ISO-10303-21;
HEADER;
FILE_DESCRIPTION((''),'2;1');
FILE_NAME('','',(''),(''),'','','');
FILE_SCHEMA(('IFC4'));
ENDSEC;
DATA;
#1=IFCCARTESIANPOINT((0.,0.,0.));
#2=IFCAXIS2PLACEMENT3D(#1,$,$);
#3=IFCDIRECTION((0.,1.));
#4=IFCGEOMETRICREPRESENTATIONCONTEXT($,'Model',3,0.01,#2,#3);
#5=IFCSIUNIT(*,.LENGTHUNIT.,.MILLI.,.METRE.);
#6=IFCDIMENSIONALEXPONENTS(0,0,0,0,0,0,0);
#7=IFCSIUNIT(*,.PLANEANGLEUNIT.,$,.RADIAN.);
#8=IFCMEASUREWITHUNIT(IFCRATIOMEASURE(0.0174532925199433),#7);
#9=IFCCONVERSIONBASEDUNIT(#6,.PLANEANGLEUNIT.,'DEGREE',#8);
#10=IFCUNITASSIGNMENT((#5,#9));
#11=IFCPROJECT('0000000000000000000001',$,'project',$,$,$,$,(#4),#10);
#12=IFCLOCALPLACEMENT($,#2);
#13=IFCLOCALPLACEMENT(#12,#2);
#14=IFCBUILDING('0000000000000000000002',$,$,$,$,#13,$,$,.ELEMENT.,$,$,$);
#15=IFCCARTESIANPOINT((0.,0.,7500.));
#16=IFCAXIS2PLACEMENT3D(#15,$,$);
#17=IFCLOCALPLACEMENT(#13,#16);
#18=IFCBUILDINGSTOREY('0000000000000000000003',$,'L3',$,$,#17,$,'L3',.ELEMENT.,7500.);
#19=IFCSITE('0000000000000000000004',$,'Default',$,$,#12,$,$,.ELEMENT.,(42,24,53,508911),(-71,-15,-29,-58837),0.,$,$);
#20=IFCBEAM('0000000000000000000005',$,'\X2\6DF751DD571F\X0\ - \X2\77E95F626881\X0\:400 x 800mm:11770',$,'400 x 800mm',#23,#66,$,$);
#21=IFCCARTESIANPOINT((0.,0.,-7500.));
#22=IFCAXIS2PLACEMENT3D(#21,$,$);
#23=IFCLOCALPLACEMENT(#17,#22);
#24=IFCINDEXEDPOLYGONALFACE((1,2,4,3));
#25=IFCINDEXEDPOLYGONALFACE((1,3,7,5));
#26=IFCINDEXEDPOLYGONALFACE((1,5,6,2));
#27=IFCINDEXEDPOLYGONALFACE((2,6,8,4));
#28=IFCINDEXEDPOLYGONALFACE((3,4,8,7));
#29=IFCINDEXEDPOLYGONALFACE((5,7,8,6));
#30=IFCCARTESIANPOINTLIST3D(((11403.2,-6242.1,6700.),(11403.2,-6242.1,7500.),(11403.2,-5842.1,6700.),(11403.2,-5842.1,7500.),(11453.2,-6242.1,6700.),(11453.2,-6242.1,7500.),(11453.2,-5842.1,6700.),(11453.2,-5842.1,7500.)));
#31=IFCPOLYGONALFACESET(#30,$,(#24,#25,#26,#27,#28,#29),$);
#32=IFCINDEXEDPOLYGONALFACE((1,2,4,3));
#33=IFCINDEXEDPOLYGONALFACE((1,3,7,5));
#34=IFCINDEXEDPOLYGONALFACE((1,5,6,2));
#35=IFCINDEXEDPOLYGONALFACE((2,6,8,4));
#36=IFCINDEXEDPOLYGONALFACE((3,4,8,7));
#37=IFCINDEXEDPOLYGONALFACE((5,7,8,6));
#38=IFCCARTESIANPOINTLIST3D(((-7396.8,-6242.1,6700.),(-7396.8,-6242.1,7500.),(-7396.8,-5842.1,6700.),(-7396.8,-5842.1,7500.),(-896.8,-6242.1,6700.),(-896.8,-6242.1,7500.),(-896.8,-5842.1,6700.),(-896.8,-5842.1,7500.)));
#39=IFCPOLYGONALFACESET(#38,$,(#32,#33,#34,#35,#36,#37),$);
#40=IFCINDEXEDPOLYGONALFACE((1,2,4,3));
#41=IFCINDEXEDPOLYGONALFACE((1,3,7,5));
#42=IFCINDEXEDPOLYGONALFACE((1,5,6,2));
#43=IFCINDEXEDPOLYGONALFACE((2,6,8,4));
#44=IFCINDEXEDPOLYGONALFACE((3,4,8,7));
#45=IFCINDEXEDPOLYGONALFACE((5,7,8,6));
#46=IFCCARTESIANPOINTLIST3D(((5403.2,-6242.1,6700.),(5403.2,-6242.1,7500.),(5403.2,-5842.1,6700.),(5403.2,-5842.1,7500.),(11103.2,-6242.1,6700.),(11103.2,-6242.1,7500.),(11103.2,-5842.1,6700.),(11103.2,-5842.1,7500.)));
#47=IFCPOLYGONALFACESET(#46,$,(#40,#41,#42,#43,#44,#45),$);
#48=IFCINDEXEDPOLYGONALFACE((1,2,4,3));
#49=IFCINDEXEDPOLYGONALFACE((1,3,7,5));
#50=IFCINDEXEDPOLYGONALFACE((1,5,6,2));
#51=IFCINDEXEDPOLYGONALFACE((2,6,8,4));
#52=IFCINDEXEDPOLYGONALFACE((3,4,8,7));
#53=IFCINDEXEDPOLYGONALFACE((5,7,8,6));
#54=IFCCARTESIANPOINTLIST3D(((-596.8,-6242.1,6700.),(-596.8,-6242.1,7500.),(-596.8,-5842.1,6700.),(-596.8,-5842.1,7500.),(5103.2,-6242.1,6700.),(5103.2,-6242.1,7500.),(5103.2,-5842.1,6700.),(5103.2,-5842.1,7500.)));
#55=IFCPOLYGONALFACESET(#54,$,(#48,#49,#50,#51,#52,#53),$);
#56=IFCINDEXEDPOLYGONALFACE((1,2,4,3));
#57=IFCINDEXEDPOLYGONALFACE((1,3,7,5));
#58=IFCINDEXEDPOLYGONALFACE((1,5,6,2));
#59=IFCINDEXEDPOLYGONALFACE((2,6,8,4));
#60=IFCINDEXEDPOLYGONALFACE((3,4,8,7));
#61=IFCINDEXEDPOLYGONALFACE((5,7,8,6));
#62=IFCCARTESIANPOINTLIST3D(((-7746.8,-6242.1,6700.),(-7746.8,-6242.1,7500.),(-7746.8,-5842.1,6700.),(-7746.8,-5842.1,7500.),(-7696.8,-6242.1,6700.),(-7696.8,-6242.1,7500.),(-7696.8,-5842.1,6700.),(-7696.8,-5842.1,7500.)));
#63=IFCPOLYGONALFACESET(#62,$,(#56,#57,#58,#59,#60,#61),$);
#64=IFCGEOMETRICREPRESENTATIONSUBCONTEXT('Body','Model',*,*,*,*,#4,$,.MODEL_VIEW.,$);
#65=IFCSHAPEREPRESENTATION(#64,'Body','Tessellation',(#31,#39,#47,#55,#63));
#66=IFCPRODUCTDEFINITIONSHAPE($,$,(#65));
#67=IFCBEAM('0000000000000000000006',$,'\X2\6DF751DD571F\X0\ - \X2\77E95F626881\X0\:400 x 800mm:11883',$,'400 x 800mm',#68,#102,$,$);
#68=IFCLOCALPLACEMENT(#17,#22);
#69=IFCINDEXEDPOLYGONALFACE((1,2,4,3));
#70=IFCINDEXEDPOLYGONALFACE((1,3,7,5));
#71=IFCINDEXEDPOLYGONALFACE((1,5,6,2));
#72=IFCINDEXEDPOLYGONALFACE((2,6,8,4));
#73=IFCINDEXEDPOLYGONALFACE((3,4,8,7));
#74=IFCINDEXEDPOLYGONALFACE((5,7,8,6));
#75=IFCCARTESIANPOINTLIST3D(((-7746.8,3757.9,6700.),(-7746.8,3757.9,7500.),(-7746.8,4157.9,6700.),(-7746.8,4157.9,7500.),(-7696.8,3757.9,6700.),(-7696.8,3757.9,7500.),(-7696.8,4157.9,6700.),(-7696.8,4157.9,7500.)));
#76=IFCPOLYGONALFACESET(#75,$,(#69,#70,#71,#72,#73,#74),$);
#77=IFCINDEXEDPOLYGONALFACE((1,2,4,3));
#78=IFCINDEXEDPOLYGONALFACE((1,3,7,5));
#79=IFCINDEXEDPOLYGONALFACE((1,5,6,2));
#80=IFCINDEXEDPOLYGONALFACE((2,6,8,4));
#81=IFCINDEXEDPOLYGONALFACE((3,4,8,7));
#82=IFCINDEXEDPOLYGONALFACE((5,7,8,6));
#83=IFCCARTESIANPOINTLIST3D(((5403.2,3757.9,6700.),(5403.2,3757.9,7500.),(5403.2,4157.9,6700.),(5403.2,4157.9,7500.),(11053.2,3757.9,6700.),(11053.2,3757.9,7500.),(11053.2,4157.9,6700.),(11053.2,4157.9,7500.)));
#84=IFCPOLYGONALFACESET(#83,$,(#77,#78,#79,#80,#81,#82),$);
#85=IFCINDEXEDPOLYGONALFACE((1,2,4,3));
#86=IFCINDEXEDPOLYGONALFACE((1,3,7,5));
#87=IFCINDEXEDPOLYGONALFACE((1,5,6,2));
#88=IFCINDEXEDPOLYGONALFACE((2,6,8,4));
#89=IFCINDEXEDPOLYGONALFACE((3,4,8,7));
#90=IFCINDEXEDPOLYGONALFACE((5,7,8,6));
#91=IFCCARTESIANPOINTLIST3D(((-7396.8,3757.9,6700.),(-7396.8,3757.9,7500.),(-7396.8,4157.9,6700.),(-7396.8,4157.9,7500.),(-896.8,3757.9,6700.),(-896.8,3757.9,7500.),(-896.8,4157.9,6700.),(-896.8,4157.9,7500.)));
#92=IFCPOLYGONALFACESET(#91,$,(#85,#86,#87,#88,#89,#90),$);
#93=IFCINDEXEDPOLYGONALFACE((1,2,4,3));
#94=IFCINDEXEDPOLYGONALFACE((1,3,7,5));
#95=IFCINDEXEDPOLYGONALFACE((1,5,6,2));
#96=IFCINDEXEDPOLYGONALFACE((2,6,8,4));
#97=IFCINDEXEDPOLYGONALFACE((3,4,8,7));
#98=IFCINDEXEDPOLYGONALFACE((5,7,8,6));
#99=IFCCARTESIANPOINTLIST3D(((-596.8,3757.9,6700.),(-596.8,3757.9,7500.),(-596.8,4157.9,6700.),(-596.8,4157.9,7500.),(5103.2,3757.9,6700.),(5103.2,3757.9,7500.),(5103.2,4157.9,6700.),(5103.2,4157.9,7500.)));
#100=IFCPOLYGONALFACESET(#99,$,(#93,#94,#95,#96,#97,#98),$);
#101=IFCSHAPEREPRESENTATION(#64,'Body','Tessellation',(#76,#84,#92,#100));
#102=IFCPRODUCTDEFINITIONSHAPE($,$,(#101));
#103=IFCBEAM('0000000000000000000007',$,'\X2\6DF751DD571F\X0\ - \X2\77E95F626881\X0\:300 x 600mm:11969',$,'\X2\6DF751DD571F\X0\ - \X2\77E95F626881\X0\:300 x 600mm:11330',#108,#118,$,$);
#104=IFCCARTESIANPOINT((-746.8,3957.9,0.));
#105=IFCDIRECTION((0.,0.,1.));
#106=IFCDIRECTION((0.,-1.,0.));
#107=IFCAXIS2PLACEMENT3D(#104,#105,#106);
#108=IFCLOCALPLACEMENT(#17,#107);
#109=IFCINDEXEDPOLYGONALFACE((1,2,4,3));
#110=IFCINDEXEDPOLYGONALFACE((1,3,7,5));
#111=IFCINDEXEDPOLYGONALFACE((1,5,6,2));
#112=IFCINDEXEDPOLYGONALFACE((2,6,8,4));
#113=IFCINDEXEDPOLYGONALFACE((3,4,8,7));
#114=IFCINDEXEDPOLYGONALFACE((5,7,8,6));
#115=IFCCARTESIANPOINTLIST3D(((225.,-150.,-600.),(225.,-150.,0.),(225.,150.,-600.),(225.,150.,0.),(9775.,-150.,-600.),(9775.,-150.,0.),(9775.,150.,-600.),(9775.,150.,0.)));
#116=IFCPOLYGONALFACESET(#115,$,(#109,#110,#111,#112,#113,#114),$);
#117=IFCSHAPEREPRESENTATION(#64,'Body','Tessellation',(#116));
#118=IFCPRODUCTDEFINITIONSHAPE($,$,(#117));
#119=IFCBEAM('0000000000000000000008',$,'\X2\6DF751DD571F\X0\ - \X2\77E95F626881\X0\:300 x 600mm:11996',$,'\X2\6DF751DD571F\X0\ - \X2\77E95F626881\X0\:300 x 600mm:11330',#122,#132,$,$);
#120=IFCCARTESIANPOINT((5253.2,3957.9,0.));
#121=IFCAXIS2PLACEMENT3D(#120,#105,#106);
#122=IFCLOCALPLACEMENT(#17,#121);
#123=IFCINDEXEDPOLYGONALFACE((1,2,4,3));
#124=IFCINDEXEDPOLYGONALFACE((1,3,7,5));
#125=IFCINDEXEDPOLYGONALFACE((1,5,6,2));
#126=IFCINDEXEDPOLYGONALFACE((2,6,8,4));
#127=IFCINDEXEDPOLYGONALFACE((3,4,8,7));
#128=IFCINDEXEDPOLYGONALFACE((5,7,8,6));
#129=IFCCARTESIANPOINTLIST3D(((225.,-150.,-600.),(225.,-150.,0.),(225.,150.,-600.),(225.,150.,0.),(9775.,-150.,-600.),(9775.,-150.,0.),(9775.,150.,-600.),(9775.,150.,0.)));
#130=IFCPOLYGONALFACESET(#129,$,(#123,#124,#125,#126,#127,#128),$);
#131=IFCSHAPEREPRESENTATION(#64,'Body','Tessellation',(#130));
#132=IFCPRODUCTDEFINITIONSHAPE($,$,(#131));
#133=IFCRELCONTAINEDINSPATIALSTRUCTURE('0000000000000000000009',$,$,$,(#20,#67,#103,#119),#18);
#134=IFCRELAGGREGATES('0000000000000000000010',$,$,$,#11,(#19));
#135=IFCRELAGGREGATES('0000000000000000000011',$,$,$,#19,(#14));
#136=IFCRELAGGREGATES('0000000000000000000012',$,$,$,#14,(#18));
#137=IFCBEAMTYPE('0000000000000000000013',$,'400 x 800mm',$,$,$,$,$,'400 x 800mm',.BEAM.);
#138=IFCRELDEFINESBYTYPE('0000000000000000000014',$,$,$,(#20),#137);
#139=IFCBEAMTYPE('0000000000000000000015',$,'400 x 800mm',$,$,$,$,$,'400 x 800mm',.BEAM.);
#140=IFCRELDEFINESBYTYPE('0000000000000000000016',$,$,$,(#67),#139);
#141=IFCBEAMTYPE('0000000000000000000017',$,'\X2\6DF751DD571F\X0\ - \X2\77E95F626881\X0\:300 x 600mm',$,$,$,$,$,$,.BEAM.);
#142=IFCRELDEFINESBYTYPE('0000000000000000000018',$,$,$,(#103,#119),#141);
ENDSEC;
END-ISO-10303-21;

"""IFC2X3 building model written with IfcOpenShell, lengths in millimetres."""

from ifc_helpers import new_model, entity, si_unit, converted_unit, direction, frame, frame_2d, origin, origin_2d_with_axis, place, context, subcontext, project, spatial, rectangle, extrude, source, transform, mapped, type_object, type_shapes, element, save


model = new_model("IFC2X3")

# Units and contexts
model_context = context("Model", 3, precision=0.01, world=origin(), true_north=direction((0.0, 1.0)))
body_context = subcontext(model_context, "Body", "Model", "MODEL_VIEW")
ifc_project = project(units=[si_unit("LENGTHUNIT", "METRE", prefix="MILLI"), converted_unit("PLANEANGLEUNIT", "DEGREE", entity("IfcRatioMeasure", 0.0174532925199433), si_unit("PLANEANGLEUNIT", "RADIAN"), dimensions=[0, 0, 0, 0, 0, 0, 0])], contexts=[model_context])

# Site, building, storey
site_placement = place(None, origin())
site = spatial("IfcSite", under=ifc_project, at=site_placement, Name="Default", CompositionType="ELEMENT", RefLatitude=(42, 24, 53, 508911), RefLongitude=(-71, -15, -29, -58837), RefElevation=0.0)
building_placement = place(site_placement, origin())
building = spatial("IfcBuilding", under=site, at=building_placement, CompositionType="ELEMENT")
storey_placement = place(building_placement, frame((0.0, 0.0, 7500.0)))
storey = spatial("IfcBuildingStorey", under=building, at=storey_placement, Name="L3", LongName="L3", CompositionType="ELEMENT", Elevation=7500.0)

# Beams
beam_type_1 = type_object("IfcBeamType", Name="400 x 800mm", ElementType="400 x 800mm", PredefinedType="BEAM")
shared_shape_1 = source(origin(), body_context, "Body", "SweptSolid", [
    extrude(rectangle(XDim=50.0, YDim=400.0, at=frame_2d((0.0, 0.0), x_axis=(1.0, 0.0))), frame((11428.2, -6042.1, 6700.0), z_axis=(0.0, 0.0, 1.0), x_axis=(-1.0, 0.0, 0.0)), (0.0, 0.0, 1.0), 800.0),
    extrude(rectangle(XDim=6500.0, YDim=400.0, at=frame_2d((640.0, -40.0), x_axis=(1.0, 0.0))), frame((-4786.8, -6002.1, 6700.0)), (0.0, 0.0, 1.0), 800.0),
    extrude(rectangle(XDim=5700.0, YDim=400.0, at=frame_2d((560.0, 40.0), x_axis=(1.0, 0.0))), frame((8813.2, -6002.1, 6700.0), z_axis=(0.0, 0.0, 1.0), x_axis=(-1.0, 0.0, 0.0)), (0.0, 0.0, 1.0), 800.0),
    extrude(rectangle(XDim=5700.0, YDim=400.0, at=frame_2d((0.0, 0.0), x_axis=(1.0, 0.0))), frame((2253.2, -6042.1, 6700.0)), (0.0, 0.0, 1.0), 800.0),
    extrude(rectangle(XDim=50.0, YDim=400.0, at=frame_2d((0.0, 0.0), x_axis=(1.0, 0.0))), frame((-7721.8, -6042.1, 6700.0)), (0.0, 0.0, 1.0), 800.0),
])
type_shapes(beam_type_1, [shared_shape_1])
beam_1_placement = place(storey_placement, frame((0.0, 0.0, -7500.0)))
element("IfcBeam", 1, at=beam_1_placement, inside=storey, type_object=beam_type_1, Name="混凝土 - 矩形梁:400 x 800mm:11770", ObjectType="400 x 800mm", context=body_context, shape_type="MappedRepresentation", body=[
    mapped(shared_shape_1, transform((0.0, 0.0, 0.0), scale=1.0)),
])
beam_type_2 = type_object("IfcBeamType", Name="400 x 800mm", ElementType="400 x 800mm", PredefinedType="BEAM")
shared_shape_2 = source(origin(), body_context, "Body", "SweptSolid", [
    extrude(rectangle(XDim=50.0, YDim=400.0, at=frame_2d((0.0, 0.0), x_axis=(1.0, 0.0))), frame((-7721.8, 3957.9, 6700.0)), (0.0, 0.0, 1.0), 800.0),
    extrude(rectangle(XDim=5650.0, YDim=400.0, at=frame_2d((0.0, 0.0), x_axis=(1.0, 0.0))), frame((8228.2, 3957.9, 6700.0), z_axis=(0.0, 0.0, 1.0), x_axis=(-1.0, 0.0, 0.0)), (0.0, 0.0, 1.0), 800.0),
    extrude(rectangle(XDim=6500.0, YDim=400.0, at=frame_2d((640.0, 40.0), x_axis=(1.0, 0.0))), frame((-4786.8, 3917.9, 6700.0)), (0.0, 0.0, 1.0), 800.0),
    extrude(rectangle(XDim=5700.0, YDim=400.0, at=origin_2d_with_axis()), frame((2253.2, 3957.9, 6700.0), z_axis=(0.0, 0.0, 1.0), x_axis=(-1.0, 0.0, 0.0)), (0.0, 0.0, 1.0), 800.0),
])
type_shapes(beam_type_2, [shared_shape_2])
beam_2_placement = place(storey_placement, frame((0.0, 0.0, -7500.0)))
element("IfcBeam", 2, at=beam_2_placement, inside=storey, type_object=beam_type_2, Name="混凝土 - 矩形梁:400 x 800mm:11883", ObjectType="400 x 800mm", context=body_context, shape_type="MappedRepresentation", body=[
    mapped(shared_shape_2, transform((0.0, 0.0, 0.0), scale=1.0)),
])
beam_type_3 = type_object("IfcBeamType", Name="混凝土 - 矩形梁:300 x 600mm", PredefinedType="BEAM")
beam_3_placement = place(storey_placement, frame((-746.8, 3957.9, 0.0), z_axis=(0.0, 0.0, 1.0), x_axis=(0.0, -1.0, 0.0)))
element("IfcBeam", 3, at=beam_3_placement, inside=storey, type_object=beam_type_3, Name="混凝土 - 矩形梁:300 x 600mm:11969", ObjectType="混凝土 - 矩形梁:300 x 600mm:11330", context=body_context, shape_type="SweptSolid", body=[
    extrude(rectangle(XDim=600.0, YDim=300.0, at=frame_2d((0.0, 0.0), x_axis=(1.0, 0.0))), frame((225.0, 0.0, -300.0), z_axis=(1.0, 0.0, 0.0), x_axis=(0.0, 0.0, -1.0)), (0.0, 0.0, 1.0), 9550.0),
])
beam_4_placement = place(storey_placement, frame((5253.2, 3957.9, 0.0), z_axis=(0.0, 0.0, 1.0), x_axis=(0.0, -1.0, 0.0)))
element("IfcBeam", 4, at=beam_4_placement, inside=storey, type_object=beam_type_3, Name="混凝土 - 矩形梁:300 x 600mm:11996", ObjectType="混凝土 - 矩形梁:300 x 600mm:11330", context=body_context, shape_type="SweptSolid", body=[
    extrude(rectangle(XDim=600.0, YDim=300.0, at=frame_2d((0.0, 0.0), x_axis=(1.0, 0.0))), frame((225.0, 0.0, -300.0), z_axis=(1.0, 0.0, 0.0), x_axis=(0.0, 0.0, -1.0)), (0.0, 0.0, 1.0), 9550.0),
])

save(model, "model.ifc")
